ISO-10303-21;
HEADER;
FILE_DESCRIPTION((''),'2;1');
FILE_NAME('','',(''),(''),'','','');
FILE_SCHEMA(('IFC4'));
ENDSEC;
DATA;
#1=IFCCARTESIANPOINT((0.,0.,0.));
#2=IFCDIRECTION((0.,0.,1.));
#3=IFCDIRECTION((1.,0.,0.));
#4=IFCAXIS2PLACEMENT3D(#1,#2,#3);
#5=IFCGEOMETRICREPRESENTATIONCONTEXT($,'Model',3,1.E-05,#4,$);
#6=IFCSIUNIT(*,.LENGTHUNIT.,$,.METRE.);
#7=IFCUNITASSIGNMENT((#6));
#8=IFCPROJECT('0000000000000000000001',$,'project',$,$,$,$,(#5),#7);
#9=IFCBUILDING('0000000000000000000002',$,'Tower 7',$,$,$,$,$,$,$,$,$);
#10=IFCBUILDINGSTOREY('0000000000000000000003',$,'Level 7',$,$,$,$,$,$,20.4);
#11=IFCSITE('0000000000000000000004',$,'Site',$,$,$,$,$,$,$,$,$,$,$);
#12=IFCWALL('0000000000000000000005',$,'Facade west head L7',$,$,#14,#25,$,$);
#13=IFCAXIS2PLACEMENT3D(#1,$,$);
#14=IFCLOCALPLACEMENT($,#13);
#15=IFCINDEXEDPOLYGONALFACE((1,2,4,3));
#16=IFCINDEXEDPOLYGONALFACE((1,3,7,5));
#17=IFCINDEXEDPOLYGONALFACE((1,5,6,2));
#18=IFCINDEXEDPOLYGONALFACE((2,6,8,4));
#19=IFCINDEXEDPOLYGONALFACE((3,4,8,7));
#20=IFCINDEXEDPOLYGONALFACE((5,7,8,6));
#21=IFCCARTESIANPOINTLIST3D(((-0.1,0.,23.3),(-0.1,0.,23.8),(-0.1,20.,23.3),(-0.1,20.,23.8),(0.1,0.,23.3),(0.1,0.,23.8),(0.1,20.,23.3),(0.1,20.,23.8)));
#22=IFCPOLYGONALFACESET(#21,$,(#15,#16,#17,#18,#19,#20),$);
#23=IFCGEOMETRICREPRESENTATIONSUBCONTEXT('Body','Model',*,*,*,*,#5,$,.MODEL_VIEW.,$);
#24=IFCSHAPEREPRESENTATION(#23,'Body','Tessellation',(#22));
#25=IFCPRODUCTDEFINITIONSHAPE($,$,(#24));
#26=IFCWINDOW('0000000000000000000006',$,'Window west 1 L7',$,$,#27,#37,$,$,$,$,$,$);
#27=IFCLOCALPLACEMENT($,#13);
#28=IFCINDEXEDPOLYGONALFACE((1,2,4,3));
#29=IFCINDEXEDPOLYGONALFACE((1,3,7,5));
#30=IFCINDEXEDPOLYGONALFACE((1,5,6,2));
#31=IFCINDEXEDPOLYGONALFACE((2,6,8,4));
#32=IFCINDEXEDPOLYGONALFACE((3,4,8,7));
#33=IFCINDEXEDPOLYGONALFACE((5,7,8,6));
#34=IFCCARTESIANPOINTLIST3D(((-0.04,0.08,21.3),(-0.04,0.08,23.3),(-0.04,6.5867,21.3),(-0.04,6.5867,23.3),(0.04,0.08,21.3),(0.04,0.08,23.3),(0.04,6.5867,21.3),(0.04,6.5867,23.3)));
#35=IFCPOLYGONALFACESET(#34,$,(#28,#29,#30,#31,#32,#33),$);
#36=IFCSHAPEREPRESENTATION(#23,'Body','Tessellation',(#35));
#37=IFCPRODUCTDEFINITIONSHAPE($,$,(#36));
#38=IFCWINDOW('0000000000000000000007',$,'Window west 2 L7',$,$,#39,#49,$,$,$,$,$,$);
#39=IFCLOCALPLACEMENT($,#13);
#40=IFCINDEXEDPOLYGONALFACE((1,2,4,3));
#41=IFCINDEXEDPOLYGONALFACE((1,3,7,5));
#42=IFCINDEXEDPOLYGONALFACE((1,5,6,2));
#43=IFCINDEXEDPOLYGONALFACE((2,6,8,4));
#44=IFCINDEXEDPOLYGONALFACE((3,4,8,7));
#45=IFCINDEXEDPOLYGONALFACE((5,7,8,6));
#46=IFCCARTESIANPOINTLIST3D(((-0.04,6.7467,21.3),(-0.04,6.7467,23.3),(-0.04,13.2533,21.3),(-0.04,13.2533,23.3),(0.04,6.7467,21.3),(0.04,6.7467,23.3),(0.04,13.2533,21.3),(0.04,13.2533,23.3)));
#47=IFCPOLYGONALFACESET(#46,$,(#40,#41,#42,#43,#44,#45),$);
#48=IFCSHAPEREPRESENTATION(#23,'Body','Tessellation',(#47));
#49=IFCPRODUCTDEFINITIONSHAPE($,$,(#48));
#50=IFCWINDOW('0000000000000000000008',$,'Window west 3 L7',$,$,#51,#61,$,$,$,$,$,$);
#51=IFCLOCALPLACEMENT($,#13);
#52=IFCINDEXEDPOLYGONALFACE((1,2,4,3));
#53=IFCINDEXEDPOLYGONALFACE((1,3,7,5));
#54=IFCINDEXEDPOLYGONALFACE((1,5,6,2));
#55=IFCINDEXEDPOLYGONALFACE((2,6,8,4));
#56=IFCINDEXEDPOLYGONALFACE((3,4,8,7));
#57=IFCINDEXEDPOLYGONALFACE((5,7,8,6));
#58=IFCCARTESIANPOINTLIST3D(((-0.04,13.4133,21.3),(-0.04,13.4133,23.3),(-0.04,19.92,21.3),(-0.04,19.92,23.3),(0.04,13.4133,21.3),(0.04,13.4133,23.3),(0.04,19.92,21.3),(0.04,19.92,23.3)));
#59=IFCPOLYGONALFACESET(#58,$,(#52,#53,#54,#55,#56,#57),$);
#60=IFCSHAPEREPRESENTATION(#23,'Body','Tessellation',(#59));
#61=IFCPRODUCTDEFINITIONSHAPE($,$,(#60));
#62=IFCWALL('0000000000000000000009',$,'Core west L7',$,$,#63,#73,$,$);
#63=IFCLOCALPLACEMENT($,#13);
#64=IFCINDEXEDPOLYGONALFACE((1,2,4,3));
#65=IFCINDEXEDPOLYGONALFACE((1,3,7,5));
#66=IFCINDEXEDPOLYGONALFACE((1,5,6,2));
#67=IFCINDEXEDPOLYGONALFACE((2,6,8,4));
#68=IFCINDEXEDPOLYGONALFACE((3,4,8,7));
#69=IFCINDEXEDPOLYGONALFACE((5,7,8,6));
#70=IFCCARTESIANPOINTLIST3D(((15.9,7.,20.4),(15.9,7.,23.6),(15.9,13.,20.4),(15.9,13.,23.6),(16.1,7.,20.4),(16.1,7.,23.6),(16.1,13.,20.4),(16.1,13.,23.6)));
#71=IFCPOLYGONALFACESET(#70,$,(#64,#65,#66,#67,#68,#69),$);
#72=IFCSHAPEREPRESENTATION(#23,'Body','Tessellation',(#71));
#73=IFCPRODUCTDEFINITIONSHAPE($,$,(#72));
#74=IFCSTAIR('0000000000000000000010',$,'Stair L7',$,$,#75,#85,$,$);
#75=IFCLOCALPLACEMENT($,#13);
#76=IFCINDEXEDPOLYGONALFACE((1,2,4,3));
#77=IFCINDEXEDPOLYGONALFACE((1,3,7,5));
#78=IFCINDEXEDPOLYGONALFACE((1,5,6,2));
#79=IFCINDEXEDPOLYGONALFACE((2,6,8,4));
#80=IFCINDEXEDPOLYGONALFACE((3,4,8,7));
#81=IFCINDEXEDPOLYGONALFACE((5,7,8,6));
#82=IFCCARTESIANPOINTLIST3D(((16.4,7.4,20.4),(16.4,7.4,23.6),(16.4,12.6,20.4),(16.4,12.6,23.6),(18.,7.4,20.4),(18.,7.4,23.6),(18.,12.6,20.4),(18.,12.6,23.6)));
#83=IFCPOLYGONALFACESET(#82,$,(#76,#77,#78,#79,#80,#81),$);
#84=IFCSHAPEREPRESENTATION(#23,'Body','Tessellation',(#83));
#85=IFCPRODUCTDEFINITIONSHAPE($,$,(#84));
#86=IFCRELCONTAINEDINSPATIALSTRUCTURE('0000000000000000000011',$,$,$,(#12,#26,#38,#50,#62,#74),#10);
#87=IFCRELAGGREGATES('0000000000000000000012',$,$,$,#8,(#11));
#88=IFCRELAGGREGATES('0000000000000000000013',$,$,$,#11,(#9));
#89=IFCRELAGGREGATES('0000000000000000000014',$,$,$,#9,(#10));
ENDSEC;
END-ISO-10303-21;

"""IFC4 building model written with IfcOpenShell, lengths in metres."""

from ifc_helpers import new_model, si_unit, frame, origin, origin_with_axes, origin_2d, place, context, subcontext, project, spatial, rectangle, extrude, element, save


model = new_model("IFC4")

# Units and contexts
model_context = context("Model", 3, precision=1e-05, world=origin_with_axes())
body_context = subcontext(model_context, "Body", "Model", "MODEL_VIEW")
ifc_project = project(units=[si_unit("LENGTHUNIT", "METRE")], contexts=[model_context])

# Site, building, storey
site = spatial("IfcSite", under=ifc_project, Name="Site")
building = spatial("IfcBuilding", under=site, Name="Tower 7")
storey = spatial("IfcBuildingStorey", under=building, Name="Level 7", Elevation=20.4)

# Wall
wall_1_placement = place(None, frame((0.0, 10.0, 23.3), z_axis=(0.0, 0.0, 1.0), x_axis=(1.0, 0.0, 0.0)))
element("IfcWall", 1, at=wall_1_placement, inside=storey, Name="Facade west head L7", context=body_context, shape_type="SweptSolid", body=[
    extrude(rectangle(XDim=0.2, YDim=20.0, at=origin_2d()), origin(), (0.0, 0.0, 1.0), 0.5),
])

# Windows
for number, where, z_axis, x_axis, name in (
    (2, (0.0, 3.3333, 21.3), (0.0, 0.0, 1.0), (1.0, 0.0, 0.0), "Window west 1 L7"),
    (3, (0.0, 10.0, 21.3), (0.0, 0.0, 1.0), (1.0, 0.0, 0.0), "Window west 2 L7"),
):
    element("IfcWindow", number, at=place(None, frame(where, z_axis=z_axis, x_axis=x_axis)), inside=storey, Name=name, context=body_context, shape_type="SweptSolid", body=[
        extrude(rectangle(XDim=0.08, YDim=6.5067, at=origin_2d()), origin(), (0.0, 0.0, 1.0), 2.0),
    ])
window_1_placement = place(None, frame((0.0, 16.6667, 21.3), z_axis=(0.0, 0.0, 1.0), x_axis=(1.0, 0.0, 0.0)))
element("IfcWindow", 4, at=window_1_placement, inside=storey, Name="Window west 3 L7", context=body_context, shape_type="SweptSolid", body=[
    extrude(rectangle(XDim=0.08, YDim=6.5067, at=origin_2d()), origin(), (0.0, 0.0, 1.0), 2.0),
])

# Wall
wall_2_placement = place(None, frame((16.0, 10.0, 20.4), z_axis=(0.0, 0.0, 1.0), x_axis=(1.0, 0.0, 0.0)))
element("IfcWall", 5, at=wall_2_placement, inside=storey, Name="Core west L7", context=body_context, shape_type="SweptSolid", body=[
    extrude(rectangle(XDim=0.2, YDim=6.0, at=origin_2d()), origin(), (0.0, 0.0, 1.0), 3.2),
])

# Stair
stair_placement = place(None, frame((17.2, 10.0, 20.4), z_axis=(0.0, 0.0, 1.0), x_axis=(1.0, 0.0, 0.0)))
element("IfcStair", 6, at=stair_placement, inside=storey, Name="Stair L7", context=body_context, shape_type="SweptSolid", body=[
    extrude(rectangle(XDim=1.6, YDim=5.2, at=origin_2d()), origin(), (0.0, 0.0, 1.0), 3.2),
])

save(model, "model.ifc")
